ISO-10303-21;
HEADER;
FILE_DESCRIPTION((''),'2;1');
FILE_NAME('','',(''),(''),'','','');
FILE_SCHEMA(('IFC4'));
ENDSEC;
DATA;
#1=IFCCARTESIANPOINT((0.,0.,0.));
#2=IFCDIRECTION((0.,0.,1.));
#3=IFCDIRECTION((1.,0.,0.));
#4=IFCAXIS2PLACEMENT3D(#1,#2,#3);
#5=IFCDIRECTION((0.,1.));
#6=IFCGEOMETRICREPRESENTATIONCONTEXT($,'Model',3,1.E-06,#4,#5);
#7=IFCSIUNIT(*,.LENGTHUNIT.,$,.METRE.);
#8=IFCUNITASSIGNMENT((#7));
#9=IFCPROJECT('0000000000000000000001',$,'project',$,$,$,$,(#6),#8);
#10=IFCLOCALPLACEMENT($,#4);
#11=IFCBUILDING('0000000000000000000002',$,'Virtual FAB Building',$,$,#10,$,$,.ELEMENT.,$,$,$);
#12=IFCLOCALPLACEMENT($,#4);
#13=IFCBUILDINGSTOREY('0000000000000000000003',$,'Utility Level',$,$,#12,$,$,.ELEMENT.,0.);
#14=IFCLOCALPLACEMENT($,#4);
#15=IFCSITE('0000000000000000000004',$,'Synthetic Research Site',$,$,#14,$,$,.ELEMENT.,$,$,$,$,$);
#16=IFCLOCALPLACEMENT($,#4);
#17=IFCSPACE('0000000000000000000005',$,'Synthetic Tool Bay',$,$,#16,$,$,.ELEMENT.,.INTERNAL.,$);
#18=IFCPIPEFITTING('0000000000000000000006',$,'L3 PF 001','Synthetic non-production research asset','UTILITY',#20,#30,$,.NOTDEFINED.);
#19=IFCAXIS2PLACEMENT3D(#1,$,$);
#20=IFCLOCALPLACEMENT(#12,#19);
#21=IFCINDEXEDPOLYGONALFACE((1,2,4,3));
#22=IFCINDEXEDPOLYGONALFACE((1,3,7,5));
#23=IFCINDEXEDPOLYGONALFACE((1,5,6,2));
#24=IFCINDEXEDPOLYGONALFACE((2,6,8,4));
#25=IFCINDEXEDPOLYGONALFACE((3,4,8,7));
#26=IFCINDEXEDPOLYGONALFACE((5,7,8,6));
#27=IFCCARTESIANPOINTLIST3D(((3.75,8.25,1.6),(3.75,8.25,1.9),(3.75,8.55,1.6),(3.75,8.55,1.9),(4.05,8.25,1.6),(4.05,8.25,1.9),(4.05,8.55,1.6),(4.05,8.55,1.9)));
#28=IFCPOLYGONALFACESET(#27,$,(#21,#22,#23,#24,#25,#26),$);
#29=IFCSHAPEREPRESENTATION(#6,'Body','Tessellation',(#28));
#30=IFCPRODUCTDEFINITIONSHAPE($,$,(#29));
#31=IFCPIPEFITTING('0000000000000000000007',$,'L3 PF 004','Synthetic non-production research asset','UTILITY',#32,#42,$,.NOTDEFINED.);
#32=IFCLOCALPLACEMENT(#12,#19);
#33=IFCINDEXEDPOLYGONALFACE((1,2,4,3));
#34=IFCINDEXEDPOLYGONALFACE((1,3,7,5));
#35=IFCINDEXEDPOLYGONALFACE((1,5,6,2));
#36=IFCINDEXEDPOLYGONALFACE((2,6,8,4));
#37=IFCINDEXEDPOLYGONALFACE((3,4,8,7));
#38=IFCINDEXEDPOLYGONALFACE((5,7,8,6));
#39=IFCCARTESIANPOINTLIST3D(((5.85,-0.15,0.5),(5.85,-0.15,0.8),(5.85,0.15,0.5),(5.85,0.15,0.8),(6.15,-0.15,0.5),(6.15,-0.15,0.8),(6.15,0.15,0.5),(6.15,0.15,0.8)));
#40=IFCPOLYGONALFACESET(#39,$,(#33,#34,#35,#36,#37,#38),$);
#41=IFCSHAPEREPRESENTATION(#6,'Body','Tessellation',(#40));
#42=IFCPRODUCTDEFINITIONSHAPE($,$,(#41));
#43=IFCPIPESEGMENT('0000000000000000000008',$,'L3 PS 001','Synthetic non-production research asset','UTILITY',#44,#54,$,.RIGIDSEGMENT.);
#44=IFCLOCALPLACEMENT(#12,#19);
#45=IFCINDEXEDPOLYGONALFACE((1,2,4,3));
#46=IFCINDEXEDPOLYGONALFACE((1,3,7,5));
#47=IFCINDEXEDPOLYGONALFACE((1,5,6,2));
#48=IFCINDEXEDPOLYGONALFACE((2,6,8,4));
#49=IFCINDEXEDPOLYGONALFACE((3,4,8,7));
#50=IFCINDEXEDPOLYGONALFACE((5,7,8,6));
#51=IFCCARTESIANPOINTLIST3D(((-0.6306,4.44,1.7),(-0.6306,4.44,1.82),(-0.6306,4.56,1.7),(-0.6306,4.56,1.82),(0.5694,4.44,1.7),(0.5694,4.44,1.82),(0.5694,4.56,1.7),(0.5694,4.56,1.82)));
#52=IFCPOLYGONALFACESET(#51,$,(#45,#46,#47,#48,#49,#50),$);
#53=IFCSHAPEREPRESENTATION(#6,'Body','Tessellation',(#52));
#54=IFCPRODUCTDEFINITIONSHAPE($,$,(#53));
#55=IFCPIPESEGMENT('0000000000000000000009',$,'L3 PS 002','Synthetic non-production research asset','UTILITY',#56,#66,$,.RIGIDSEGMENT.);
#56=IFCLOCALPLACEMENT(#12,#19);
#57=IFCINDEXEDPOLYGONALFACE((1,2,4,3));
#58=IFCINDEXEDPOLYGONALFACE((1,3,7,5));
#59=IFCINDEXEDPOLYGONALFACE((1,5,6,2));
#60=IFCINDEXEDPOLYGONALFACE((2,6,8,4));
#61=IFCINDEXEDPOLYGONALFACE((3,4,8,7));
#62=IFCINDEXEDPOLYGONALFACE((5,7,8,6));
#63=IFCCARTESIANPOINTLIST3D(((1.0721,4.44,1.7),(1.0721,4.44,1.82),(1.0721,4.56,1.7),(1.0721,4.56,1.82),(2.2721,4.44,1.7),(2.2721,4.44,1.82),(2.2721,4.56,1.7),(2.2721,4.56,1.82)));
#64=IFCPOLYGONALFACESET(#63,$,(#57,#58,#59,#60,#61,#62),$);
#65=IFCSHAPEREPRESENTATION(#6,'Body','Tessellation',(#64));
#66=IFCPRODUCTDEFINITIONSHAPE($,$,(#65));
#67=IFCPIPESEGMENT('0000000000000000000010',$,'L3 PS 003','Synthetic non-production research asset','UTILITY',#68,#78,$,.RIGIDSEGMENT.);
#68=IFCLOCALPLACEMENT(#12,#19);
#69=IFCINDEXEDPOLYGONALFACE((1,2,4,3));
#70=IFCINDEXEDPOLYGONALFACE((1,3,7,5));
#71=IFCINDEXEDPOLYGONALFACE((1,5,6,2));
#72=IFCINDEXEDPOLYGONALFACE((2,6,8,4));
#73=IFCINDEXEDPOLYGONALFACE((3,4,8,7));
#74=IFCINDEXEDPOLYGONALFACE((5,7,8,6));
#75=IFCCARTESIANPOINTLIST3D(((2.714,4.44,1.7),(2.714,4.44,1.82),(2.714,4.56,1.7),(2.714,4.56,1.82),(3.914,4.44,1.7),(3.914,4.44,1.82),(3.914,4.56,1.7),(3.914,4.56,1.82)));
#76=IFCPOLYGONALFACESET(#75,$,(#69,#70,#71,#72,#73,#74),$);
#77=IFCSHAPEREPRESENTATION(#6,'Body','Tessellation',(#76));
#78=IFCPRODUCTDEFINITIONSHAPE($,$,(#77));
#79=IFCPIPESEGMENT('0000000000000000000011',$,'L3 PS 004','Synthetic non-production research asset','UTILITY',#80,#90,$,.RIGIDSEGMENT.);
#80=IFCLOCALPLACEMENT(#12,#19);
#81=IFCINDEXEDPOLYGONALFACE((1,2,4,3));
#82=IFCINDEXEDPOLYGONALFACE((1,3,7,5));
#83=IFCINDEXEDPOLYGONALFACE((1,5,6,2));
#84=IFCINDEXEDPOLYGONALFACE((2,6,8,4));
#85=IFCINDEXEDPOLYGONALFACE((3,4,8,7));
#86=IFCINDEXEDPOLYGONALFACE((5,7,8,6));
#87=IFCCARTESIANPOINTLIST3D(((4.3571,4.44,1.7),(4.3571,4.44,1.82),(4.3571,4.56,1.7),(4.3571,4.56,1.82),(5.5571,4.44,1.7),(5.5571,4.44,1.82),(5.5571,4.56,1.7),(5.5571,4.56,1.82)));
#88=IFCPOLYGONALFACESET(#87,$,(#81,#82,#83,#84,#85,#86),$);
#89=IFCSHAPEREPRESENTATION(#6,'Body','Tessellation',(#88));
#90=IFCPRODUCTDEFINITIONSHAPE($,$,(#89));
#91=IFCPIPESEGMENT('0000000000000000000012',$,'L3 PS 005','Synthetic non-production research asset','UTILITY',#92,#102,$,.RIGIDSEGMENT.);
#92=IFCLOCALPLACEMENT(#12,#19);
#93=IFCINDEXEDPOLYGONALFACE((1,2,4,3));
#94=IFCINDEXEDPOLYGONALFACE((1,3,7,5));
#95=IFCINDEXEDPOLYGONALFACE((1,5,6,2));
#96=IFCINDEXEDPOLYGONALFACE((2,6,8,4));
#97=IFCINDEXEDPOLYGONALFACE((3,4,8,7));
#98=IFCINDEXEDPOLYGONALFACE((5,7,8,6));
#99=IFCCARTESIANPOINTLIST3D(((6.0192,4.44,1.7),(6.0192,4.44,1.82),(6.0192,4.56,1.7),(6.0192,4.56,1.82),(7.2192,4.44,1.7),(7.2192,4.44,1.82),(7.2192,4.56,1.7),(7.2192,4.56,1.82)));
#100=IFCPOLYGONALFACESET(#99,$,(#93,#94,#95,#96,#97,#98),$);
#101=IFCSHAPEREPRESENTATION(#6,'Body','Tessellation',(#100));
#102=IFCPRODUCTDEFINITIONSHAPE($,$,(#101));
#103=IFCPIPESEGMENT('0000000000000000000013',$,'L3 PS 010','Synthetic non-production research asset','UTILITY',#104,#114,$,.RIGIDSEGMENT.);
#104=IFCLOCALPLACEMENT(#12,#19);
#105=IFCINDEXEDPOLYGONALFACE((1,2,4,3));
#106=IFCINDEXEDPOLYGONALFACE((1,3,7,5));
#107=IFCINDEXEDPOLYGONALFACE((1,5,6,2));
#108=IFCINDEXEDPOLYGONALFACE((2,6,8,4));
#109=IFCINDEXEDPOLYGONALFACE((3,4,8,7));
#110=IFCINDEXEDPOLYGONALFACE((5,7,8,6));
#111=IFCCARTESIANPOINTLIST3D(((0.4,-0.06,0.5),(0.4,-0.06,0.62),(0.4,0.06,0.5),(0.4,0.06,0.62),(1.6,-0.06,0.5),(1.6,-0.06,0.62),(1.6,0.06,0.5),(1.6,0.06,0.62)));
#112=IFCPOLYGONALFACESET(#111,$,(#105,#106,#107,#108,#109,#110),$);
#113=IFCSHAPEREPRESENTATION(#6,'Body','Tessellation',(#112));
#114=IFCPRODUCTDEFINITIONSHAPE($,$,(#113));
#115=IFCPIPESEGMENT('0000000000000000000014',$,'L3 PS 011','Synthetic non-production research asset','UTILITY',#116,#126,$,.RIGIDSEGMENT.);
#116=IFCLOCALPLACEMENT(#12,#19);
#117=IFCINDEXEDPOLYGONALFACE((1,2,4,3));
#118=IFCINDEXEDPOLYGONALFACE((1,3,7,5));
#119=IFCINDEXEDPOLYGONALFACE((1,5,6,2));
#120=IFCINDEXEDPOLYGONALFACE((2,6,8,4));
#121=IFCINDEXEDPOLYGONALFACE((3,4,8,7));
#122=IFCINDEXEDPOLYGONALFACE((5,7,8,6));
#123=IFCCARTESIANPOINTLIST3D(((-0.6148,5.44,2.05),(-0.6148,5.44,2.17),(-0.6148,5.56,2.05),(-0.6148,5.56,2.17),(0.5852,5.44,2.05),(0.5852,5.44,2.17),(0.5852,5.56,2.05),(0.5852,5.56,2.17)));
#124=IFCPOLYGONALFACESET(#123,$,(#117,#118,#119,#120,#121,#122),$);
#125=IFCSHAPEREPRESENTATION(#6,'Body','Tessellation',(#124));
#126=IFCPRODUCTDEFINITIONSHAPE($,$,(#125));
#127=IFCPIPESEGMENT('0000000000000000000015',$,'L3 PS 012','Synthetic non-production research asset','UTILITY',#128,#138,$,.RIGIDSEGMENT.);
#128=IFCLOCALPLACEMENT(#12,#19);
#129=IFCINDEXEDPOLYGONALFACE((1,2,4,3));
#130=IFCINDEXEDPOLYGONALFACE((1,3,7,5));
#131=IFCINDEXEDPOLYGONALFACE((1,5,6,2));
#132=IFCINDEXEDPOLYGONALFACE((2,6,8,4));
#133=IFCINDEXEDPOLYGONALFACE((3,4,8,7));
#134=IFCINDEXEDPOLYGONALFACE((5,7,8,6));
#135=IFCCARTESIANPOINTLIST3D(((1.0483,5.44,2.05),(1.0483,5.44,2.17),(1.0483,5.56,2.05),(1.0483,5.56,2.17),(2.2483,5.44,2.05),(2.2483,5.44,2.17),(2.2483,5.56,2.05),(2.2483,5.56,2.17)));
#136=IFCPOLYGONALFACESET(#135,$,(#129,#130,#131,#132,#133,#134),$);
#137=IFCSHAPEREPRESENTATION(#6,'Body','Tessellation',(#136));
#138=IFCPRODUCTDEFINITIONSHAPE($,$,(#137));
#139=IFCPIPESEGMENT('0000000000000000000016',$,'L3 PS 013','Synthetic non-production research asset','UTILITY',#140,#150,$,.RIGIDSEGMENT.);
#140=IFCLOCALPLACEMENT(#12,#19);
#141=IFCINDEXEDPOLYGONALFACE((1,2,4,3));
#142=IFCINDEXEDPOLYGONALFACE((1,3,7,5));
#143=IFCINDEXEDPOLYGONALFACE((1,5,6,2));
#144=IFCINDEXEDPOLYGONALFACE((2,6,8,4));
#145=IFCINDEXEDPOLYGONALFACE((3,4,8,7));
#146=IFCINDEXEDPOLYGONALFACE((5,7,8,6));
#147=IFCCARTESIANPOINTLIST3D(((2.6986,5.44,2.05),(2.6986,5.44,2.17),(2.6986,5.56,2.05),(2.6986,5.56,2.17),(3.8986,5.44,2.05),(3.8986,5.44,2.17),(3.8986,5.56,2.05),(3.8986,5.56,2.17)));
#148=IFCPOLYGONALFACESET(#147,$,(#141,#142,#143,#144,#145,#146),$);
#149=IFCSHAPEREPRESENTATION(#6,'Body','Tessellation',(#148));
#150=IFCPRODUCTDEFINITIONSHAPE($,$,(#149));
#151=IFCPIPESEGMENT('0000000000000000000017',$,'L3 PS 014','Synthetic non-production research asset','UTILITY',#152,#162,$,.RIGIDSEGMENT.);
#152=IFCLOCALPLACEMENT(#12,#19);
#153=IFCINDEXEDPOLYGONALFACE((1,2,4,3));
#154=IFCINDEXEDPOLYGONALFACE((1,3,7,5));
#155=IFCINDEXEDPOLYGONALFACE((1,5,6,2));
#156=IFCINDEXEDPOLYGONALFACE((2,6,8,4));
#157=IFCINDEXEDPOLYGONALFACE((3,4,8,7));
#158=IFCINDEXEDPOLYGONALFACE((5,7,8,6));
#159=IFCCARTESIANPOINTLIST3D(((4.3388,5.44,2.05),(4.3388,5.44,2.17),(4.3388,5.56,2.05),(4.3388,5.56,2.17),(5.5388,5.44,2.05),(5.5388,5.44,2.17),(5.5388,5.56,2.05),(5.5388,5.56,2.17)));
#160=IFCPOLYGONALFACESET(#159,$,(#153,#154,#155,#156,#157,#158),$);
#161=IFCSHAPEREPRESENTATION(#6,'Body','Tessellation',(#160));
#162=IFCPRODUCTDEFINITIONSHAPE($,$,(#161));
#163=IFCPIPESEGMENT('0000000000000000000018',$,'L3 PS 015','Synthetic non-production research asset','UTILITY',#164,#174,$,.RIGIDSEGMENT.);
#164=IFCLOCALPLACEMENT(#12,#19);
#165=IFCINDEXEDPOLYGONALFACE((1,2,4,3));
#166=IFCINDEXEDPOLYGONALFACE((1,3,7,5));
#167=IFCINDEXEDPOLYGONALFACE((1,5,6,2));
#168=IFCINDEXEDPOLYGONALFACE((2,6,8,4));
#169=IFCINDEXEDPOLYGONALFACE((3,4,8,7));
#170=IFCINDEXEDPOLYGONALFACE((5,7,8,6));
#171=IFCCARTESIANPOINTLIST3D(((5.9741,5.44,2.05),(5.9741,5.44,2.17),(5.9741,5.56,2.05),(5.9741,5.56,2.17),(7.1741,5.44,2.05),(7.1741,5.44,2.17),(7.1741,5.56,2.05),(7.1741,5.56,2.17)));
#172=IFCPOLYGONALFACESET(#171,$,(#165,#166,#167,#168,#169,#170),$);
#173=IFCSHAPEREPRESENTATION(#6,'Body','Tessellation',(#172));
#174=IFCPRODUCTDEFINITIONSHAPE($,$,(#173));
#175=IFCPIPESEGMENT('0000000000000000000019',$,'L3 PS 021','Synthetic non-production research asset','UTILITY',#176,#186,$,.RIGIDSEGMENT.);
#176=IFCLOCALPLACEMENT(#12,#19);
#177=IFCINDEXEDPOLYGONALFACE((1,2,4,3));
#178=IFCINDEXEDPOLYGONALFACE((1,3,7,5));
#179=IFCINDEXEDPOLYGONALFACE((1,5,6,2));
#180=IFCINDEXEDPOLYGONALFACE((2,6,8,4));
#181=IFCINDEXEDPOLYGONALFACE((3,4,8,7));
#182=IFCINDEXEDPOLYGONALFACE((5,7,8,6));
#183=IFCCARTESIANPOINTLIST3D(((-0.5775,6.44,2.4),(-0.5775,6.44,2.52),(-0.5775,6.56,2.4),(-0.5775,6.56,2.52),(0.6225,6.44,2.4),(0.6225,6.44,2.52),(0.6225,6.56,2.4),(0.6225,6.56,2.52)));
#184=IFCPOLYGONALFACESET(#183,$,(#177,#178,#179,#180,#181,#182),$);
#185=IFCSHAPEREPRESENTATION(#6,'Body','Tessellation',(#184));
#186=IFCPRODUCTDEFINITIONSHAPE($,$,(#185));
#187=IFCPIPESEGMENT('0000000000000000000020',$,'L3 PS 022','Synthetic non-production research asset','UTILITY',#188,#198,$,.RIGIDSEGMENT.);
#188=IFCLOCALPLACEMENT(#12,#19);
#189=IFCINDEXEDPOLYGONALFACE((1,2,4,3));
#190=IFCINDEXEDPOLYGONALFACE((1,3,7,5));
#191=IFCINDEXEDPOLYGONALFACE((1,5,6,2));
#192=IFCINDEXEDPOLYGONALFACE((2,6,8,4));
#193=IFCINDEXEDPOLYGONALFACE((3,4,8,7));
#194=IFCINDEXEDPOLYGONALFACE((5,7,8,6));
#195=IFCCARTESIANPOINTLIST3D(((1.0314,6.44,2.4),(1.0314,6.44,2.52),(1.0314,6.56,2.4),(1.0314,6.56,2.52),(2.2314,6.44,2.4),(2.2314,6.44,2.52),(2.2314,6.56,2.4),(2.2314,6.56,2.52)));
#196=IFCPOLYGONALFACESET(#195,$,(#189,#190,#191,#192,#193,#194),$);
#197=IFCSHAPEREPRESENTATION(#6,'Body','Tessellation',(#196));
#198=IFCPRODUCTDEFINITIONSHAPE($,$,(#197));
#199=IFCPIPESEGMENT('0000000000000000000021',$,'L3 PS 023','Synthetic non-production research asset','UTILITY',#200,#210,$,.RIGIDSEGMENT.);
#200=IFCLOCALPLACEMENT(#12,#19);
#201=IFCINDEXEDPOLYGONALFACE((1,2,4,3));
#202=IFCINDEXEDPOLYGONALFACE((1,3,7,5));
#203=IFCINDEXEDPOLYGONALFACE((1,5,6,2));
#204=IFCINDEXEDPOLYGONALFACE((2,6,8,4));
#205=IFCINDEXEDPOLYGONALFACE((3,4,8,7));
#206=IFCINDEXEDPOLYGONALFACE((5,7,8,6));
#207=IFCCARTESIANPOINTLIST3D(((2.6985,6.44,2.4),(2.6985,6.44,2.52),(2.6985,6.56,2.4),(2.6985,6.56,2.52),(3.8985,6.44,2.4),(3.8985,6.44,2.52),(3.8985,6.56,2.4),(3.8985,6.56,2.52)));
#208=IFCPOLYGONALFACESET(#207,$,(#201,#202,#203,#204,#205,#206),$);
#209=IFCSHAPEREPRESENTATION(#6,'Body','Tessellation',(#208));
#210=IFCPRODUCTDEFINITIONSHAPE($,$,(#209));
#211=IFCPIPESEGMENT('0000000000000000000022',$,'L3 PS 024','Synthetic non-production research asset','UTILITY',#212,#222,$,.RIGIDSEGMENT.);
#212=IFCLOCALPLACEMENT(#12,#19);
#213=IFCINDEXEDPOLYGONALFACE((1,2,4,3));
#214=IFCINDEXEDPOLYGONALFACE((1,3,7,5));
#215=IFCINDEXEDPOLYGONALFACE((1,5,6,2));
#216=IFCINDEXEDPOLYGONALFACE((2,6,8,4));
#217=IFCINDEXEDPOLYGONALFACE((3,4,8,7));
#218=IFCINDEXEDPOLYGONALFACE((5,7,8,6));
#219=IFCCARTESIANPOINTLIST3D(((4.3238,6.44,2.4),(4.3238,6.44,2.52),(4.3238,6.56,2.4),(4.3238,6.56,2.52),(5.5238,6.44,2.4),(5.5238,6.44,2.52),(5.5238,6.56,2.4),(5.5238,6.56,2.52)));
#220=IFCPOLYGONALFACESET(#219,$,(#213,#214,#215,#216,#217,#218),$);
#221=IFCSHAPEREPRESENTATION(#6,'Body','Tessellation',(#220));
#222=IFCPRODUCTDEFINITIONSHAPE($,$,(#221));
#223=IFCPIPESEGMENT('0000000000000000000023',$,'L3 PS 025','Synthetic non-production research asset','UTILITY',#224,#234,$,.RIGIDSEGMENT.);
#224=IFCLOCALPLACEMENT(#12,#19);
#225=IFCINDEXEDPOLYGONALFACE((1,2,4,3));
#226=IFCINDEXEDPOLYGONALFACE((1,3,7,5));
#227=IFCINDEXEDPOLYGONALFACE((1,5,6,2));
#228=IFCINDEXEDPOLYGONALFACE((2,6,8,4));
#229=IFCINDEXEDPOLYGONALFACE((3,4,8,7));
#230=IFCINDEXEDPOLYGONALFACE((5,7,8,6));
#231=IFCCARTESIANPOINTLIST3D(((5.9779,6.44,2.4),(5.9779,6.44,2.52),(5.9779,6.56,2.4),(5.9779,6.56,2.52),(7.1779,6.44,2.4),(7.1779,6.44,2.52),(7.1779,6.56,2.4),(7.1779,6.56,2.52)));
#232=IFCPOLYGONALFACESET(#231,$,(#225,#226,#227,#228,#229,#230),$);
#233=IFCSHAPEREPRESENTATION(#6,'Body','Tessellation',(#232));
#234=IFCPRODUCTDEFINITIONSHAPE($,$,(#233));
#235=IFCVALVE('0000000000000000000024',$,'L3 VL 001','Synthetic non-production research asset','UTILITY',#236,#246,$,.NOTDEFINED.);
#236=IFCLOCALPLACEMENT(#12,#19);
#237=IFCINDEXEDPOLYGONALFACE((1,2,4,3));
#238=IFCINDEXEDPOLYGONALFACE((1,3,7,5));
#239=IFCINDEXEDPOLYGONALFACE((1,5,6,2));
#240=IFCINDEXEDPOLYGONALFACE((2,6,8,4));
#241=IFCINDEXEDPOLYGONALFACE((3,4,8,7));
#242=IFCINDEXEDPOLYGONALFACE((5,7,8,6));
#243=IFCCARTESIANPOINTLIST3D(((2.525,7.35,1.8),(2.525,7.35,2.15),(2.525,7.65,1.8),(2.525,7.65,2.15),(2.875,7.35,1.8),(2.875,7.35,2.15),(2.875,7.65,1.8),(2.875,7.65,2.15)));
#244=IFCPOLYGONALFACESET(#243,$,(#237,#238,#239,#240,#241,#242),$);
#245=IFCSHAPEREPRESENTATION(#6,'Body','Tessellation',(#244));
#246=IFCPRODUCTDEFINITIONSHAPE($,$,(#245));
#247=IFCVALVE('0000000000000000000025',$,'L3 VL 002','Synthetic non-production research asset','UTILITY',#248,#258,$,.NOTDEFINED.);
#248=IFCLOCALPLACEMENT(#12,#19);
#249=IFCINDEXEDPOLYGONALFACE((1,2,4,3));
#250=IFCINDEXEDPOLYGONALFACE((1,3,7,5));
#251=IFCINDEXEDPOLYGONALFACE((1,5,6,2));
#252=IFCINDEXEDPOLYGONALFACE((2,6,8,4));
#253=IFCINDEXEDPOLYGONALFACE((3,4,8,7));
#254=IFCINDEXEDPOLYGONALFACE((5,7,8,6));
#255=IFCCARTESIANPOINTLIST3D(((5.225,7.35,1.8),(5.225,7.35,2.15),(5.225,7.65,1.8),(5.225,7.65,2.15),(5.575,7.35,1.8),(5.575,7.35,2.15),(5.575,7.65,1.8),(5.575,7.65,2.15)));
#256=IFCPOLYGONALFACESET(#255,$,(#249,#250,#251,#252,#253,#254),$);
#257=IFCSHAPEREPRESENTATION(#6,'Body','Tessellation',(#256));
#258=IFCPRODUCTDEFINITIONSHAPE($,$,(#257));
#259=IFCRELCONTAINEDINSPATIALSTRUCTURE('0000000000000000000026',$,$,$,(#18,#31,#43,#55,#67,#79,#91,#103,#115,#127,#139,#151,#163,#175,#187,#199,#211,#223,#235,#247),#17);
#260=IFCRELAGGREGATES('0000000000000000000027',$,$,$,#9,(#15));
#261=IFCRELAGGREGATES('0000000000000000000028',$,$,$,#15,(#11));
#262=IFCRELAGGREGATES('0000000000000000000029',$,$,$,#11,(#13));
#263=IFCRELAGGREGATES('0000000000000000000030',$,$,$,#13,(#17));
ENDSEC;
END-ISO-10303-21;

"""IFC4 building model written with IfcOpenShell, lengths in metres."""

from ifc_helpers import new_model, si_unit, direction, frame, origin_with_axes, origin_2d_with_axis, place, context, project, spatial, rectangle, extrude, element, save


model = new_model("IFC4")

# Units and contexts
model_context = context("Model", 3, precision=1e-06, world=origin_with_axes(), true_north=direction((0.0, 1.0)))
ifc_project = project(units=[si_unit("LENGTHUNIT", "METRE")], contexts=[model_context])

# Site, building, storey, space
site_placement = place(None, origin_with_axes())
site = spatial("IfcSite", under=ifc_project, at=site_placement, Name="Synthetic Research Site", CompositionType="ELEMENT")
building_placement = place(None, origin_with_axes())
building = spatial("IfcBuilding", under=site, at=building_placement, Name="Virtual FAB Building", CompositionType="ELEMENT")
storey_placement = place(None, origin_with_axes())
storey = spatial("IfcBuildingStorey", under=building, at=storey_placement, Name="Utility Level", CompositionType="ELEMENT", Elevation=0.0)
space_placement = place(None, origin_with_axes())
space = spatial("IfcSpace", under=storey, at=space_placement, Name="Synthetic Tool Bay", CompositionType="ELEMENT", PredefinedType="INTERNAL")

# Pipe fittings
for number, where, z_axis, x_axis, name in (
    (1, (3.9, 8.4, 1.6), (0.0, 0.0, 1.0), (1.0, 0.0, 0.0), "L3 PF 001"),
    (2, (6.0, 0.0, 0.5), (0.0, 0.0, 1.0), (1.0, 0.0, 0.0), "L3 PF 004"),
):
    element("IfcPipeFitting", number, at=place(None, frame(where, z_axis=z_axis, x_axis=x_axis)), inside=space, Name=name, Description="Synthetic non-production research asset", ObjectType="UTILITY", PredefinedType="NOTDEFINED", context=model_context, shape_type="SweptSolid", body=[
        extrude(rectangle(XDim=0.3, YDim=0.3, at=origin_2d_with_axis()), origin_with_axes(), (0.0, 0.0, 1.0), 0.3),
    ])

# Pipe segments
for number, where, z_axis, x_axis, name in (
    (3, (-0.0306, 4.5, 1.7), (0.0, 0.0, 1.0), (1.0, 0.0, 0.0), "L3 PS 001"),
    (4, (1.6721, 4.5, 1.7), (0.0, 0.0, 1.0), (1.0, 0.0, 0.0), "L3 PS 002"),
    (5, (3.314, 4.5, 1.7), (0.0, 0.0, 1.0), (1.0, 0.0, 0.0), "L3 PS 003"),
    (6, (4.9571, 4.5, 1.7), (0.0, 0.0, 1.0), (1.0, 0.0, 0.0), "L3 PS 004"),
    (7, (6.6192, 4.5, 1.7), (0.0, 0.0, 1.0), (1.0, 0.0, 0.0), "L3 PS 005"),
    (8, (1.0, 0.0, 0.5), (0.0, 0.0, 1.0), (1.0, 0.0, 0.0), "L3 PS 010"),
    (9, (-0.0148, 5.5, 2.05), (0.0, 0.0, 1.0), (1.0, 0.0, 0.0), "L3 PS 011"),
    (10, (1.6483, 5.5, 2.05), (0.0, 0.0, 1.0), (1.0, 0.0, 0.0), "L3 PS 012"),
    (11, (3.2986, 5.5, 2.05), (0.0, 0.0, 1.0), (1.0, 0.0, 0.0), "L3 PS 013"),
    (12, (4.9388, 5.5, 2.05), (0.0, 0.0, 1.0), (1.0, 0.0, 0.0), "L3 PS 014"),
    (13, (6.5741, 5.5, 2.05), (0.0, 0.0, 1.0), (1.0, 0.0, 0.0), "L3 PS 015"),
    (14, (0.0225, 6.5, 2.4), (0.0, 0.0, 1.0), (1.0, 0.0, 0.0), "L3 PS 021"),
    (15, (1.6314, 6.5, 2.4), (0.0, 0.0, 1.0), (1.0, 0.0, 0.0), "L3 PS 022"),
    (16, (3.2985, 6.5, 2.4), (0.0, 0.0, 1.0), (1.0, 0.0, 0.0), "L3 PS 023"),
    (17, (4.9238, 6.5, 2.4), (0.0, 0.0, 1.0), (1.0, 0.0, 0.0), "L3 PS 024"),
    (18, (6.5779, 6.5, 2.4), (0.0, 0.0, 1.0), (1.0, 0.0, 0.0), "L3 PS 025"),
):
    element("IfcPipeSegment", number, at=place(None, frame(where, z_axis=z_axis, x_axis=x_axis)), inside=space, Name=name, Description="Synthetic non-production research asset", ObjectType="UTILITY", PredefinedType="RIGIDSEGMENT", context=model_context, shape_type="SweptSolid", body=[
        extrude(rectangle(XDim=1.2, YDim=0.12, at=origin_2d_with_axis()), origin_with_axes(), (0.0, 0.0, 1.0), 0.12),
    ])

# Valves
for number, where, z_axis, x_axis, name in (
    (19, (2.7, 7.5, 1.8), (0.0, 0.0, 1.0), (1.0, 0.0, 0.0), "L3 VL 001"),
    (20, (5.4, 7.5, 1.8), (0.0, 0.0, 1.0), (1.0, 0.0, 0.0), "L3 VL 002"),
):
    element("IfcValve", number, at=place(None, frame(where, z_axis=z_axis, x_axis=x_axis)), inside=space, Name=name, Description="Synthetic non-production research asset", ObjectType="UTILITY", PredefinedType="NOTDEFINED", context=model_context, shape_type="SweptSolid", body=[
        extrude(rectangle(XDim=0.35, YDim=0.3, at=origin_2d_with_axis()), origin_with_axes(), (0.0, 0.0, 1.0), 0.35),
    ])

save(model, "model.ifc")
